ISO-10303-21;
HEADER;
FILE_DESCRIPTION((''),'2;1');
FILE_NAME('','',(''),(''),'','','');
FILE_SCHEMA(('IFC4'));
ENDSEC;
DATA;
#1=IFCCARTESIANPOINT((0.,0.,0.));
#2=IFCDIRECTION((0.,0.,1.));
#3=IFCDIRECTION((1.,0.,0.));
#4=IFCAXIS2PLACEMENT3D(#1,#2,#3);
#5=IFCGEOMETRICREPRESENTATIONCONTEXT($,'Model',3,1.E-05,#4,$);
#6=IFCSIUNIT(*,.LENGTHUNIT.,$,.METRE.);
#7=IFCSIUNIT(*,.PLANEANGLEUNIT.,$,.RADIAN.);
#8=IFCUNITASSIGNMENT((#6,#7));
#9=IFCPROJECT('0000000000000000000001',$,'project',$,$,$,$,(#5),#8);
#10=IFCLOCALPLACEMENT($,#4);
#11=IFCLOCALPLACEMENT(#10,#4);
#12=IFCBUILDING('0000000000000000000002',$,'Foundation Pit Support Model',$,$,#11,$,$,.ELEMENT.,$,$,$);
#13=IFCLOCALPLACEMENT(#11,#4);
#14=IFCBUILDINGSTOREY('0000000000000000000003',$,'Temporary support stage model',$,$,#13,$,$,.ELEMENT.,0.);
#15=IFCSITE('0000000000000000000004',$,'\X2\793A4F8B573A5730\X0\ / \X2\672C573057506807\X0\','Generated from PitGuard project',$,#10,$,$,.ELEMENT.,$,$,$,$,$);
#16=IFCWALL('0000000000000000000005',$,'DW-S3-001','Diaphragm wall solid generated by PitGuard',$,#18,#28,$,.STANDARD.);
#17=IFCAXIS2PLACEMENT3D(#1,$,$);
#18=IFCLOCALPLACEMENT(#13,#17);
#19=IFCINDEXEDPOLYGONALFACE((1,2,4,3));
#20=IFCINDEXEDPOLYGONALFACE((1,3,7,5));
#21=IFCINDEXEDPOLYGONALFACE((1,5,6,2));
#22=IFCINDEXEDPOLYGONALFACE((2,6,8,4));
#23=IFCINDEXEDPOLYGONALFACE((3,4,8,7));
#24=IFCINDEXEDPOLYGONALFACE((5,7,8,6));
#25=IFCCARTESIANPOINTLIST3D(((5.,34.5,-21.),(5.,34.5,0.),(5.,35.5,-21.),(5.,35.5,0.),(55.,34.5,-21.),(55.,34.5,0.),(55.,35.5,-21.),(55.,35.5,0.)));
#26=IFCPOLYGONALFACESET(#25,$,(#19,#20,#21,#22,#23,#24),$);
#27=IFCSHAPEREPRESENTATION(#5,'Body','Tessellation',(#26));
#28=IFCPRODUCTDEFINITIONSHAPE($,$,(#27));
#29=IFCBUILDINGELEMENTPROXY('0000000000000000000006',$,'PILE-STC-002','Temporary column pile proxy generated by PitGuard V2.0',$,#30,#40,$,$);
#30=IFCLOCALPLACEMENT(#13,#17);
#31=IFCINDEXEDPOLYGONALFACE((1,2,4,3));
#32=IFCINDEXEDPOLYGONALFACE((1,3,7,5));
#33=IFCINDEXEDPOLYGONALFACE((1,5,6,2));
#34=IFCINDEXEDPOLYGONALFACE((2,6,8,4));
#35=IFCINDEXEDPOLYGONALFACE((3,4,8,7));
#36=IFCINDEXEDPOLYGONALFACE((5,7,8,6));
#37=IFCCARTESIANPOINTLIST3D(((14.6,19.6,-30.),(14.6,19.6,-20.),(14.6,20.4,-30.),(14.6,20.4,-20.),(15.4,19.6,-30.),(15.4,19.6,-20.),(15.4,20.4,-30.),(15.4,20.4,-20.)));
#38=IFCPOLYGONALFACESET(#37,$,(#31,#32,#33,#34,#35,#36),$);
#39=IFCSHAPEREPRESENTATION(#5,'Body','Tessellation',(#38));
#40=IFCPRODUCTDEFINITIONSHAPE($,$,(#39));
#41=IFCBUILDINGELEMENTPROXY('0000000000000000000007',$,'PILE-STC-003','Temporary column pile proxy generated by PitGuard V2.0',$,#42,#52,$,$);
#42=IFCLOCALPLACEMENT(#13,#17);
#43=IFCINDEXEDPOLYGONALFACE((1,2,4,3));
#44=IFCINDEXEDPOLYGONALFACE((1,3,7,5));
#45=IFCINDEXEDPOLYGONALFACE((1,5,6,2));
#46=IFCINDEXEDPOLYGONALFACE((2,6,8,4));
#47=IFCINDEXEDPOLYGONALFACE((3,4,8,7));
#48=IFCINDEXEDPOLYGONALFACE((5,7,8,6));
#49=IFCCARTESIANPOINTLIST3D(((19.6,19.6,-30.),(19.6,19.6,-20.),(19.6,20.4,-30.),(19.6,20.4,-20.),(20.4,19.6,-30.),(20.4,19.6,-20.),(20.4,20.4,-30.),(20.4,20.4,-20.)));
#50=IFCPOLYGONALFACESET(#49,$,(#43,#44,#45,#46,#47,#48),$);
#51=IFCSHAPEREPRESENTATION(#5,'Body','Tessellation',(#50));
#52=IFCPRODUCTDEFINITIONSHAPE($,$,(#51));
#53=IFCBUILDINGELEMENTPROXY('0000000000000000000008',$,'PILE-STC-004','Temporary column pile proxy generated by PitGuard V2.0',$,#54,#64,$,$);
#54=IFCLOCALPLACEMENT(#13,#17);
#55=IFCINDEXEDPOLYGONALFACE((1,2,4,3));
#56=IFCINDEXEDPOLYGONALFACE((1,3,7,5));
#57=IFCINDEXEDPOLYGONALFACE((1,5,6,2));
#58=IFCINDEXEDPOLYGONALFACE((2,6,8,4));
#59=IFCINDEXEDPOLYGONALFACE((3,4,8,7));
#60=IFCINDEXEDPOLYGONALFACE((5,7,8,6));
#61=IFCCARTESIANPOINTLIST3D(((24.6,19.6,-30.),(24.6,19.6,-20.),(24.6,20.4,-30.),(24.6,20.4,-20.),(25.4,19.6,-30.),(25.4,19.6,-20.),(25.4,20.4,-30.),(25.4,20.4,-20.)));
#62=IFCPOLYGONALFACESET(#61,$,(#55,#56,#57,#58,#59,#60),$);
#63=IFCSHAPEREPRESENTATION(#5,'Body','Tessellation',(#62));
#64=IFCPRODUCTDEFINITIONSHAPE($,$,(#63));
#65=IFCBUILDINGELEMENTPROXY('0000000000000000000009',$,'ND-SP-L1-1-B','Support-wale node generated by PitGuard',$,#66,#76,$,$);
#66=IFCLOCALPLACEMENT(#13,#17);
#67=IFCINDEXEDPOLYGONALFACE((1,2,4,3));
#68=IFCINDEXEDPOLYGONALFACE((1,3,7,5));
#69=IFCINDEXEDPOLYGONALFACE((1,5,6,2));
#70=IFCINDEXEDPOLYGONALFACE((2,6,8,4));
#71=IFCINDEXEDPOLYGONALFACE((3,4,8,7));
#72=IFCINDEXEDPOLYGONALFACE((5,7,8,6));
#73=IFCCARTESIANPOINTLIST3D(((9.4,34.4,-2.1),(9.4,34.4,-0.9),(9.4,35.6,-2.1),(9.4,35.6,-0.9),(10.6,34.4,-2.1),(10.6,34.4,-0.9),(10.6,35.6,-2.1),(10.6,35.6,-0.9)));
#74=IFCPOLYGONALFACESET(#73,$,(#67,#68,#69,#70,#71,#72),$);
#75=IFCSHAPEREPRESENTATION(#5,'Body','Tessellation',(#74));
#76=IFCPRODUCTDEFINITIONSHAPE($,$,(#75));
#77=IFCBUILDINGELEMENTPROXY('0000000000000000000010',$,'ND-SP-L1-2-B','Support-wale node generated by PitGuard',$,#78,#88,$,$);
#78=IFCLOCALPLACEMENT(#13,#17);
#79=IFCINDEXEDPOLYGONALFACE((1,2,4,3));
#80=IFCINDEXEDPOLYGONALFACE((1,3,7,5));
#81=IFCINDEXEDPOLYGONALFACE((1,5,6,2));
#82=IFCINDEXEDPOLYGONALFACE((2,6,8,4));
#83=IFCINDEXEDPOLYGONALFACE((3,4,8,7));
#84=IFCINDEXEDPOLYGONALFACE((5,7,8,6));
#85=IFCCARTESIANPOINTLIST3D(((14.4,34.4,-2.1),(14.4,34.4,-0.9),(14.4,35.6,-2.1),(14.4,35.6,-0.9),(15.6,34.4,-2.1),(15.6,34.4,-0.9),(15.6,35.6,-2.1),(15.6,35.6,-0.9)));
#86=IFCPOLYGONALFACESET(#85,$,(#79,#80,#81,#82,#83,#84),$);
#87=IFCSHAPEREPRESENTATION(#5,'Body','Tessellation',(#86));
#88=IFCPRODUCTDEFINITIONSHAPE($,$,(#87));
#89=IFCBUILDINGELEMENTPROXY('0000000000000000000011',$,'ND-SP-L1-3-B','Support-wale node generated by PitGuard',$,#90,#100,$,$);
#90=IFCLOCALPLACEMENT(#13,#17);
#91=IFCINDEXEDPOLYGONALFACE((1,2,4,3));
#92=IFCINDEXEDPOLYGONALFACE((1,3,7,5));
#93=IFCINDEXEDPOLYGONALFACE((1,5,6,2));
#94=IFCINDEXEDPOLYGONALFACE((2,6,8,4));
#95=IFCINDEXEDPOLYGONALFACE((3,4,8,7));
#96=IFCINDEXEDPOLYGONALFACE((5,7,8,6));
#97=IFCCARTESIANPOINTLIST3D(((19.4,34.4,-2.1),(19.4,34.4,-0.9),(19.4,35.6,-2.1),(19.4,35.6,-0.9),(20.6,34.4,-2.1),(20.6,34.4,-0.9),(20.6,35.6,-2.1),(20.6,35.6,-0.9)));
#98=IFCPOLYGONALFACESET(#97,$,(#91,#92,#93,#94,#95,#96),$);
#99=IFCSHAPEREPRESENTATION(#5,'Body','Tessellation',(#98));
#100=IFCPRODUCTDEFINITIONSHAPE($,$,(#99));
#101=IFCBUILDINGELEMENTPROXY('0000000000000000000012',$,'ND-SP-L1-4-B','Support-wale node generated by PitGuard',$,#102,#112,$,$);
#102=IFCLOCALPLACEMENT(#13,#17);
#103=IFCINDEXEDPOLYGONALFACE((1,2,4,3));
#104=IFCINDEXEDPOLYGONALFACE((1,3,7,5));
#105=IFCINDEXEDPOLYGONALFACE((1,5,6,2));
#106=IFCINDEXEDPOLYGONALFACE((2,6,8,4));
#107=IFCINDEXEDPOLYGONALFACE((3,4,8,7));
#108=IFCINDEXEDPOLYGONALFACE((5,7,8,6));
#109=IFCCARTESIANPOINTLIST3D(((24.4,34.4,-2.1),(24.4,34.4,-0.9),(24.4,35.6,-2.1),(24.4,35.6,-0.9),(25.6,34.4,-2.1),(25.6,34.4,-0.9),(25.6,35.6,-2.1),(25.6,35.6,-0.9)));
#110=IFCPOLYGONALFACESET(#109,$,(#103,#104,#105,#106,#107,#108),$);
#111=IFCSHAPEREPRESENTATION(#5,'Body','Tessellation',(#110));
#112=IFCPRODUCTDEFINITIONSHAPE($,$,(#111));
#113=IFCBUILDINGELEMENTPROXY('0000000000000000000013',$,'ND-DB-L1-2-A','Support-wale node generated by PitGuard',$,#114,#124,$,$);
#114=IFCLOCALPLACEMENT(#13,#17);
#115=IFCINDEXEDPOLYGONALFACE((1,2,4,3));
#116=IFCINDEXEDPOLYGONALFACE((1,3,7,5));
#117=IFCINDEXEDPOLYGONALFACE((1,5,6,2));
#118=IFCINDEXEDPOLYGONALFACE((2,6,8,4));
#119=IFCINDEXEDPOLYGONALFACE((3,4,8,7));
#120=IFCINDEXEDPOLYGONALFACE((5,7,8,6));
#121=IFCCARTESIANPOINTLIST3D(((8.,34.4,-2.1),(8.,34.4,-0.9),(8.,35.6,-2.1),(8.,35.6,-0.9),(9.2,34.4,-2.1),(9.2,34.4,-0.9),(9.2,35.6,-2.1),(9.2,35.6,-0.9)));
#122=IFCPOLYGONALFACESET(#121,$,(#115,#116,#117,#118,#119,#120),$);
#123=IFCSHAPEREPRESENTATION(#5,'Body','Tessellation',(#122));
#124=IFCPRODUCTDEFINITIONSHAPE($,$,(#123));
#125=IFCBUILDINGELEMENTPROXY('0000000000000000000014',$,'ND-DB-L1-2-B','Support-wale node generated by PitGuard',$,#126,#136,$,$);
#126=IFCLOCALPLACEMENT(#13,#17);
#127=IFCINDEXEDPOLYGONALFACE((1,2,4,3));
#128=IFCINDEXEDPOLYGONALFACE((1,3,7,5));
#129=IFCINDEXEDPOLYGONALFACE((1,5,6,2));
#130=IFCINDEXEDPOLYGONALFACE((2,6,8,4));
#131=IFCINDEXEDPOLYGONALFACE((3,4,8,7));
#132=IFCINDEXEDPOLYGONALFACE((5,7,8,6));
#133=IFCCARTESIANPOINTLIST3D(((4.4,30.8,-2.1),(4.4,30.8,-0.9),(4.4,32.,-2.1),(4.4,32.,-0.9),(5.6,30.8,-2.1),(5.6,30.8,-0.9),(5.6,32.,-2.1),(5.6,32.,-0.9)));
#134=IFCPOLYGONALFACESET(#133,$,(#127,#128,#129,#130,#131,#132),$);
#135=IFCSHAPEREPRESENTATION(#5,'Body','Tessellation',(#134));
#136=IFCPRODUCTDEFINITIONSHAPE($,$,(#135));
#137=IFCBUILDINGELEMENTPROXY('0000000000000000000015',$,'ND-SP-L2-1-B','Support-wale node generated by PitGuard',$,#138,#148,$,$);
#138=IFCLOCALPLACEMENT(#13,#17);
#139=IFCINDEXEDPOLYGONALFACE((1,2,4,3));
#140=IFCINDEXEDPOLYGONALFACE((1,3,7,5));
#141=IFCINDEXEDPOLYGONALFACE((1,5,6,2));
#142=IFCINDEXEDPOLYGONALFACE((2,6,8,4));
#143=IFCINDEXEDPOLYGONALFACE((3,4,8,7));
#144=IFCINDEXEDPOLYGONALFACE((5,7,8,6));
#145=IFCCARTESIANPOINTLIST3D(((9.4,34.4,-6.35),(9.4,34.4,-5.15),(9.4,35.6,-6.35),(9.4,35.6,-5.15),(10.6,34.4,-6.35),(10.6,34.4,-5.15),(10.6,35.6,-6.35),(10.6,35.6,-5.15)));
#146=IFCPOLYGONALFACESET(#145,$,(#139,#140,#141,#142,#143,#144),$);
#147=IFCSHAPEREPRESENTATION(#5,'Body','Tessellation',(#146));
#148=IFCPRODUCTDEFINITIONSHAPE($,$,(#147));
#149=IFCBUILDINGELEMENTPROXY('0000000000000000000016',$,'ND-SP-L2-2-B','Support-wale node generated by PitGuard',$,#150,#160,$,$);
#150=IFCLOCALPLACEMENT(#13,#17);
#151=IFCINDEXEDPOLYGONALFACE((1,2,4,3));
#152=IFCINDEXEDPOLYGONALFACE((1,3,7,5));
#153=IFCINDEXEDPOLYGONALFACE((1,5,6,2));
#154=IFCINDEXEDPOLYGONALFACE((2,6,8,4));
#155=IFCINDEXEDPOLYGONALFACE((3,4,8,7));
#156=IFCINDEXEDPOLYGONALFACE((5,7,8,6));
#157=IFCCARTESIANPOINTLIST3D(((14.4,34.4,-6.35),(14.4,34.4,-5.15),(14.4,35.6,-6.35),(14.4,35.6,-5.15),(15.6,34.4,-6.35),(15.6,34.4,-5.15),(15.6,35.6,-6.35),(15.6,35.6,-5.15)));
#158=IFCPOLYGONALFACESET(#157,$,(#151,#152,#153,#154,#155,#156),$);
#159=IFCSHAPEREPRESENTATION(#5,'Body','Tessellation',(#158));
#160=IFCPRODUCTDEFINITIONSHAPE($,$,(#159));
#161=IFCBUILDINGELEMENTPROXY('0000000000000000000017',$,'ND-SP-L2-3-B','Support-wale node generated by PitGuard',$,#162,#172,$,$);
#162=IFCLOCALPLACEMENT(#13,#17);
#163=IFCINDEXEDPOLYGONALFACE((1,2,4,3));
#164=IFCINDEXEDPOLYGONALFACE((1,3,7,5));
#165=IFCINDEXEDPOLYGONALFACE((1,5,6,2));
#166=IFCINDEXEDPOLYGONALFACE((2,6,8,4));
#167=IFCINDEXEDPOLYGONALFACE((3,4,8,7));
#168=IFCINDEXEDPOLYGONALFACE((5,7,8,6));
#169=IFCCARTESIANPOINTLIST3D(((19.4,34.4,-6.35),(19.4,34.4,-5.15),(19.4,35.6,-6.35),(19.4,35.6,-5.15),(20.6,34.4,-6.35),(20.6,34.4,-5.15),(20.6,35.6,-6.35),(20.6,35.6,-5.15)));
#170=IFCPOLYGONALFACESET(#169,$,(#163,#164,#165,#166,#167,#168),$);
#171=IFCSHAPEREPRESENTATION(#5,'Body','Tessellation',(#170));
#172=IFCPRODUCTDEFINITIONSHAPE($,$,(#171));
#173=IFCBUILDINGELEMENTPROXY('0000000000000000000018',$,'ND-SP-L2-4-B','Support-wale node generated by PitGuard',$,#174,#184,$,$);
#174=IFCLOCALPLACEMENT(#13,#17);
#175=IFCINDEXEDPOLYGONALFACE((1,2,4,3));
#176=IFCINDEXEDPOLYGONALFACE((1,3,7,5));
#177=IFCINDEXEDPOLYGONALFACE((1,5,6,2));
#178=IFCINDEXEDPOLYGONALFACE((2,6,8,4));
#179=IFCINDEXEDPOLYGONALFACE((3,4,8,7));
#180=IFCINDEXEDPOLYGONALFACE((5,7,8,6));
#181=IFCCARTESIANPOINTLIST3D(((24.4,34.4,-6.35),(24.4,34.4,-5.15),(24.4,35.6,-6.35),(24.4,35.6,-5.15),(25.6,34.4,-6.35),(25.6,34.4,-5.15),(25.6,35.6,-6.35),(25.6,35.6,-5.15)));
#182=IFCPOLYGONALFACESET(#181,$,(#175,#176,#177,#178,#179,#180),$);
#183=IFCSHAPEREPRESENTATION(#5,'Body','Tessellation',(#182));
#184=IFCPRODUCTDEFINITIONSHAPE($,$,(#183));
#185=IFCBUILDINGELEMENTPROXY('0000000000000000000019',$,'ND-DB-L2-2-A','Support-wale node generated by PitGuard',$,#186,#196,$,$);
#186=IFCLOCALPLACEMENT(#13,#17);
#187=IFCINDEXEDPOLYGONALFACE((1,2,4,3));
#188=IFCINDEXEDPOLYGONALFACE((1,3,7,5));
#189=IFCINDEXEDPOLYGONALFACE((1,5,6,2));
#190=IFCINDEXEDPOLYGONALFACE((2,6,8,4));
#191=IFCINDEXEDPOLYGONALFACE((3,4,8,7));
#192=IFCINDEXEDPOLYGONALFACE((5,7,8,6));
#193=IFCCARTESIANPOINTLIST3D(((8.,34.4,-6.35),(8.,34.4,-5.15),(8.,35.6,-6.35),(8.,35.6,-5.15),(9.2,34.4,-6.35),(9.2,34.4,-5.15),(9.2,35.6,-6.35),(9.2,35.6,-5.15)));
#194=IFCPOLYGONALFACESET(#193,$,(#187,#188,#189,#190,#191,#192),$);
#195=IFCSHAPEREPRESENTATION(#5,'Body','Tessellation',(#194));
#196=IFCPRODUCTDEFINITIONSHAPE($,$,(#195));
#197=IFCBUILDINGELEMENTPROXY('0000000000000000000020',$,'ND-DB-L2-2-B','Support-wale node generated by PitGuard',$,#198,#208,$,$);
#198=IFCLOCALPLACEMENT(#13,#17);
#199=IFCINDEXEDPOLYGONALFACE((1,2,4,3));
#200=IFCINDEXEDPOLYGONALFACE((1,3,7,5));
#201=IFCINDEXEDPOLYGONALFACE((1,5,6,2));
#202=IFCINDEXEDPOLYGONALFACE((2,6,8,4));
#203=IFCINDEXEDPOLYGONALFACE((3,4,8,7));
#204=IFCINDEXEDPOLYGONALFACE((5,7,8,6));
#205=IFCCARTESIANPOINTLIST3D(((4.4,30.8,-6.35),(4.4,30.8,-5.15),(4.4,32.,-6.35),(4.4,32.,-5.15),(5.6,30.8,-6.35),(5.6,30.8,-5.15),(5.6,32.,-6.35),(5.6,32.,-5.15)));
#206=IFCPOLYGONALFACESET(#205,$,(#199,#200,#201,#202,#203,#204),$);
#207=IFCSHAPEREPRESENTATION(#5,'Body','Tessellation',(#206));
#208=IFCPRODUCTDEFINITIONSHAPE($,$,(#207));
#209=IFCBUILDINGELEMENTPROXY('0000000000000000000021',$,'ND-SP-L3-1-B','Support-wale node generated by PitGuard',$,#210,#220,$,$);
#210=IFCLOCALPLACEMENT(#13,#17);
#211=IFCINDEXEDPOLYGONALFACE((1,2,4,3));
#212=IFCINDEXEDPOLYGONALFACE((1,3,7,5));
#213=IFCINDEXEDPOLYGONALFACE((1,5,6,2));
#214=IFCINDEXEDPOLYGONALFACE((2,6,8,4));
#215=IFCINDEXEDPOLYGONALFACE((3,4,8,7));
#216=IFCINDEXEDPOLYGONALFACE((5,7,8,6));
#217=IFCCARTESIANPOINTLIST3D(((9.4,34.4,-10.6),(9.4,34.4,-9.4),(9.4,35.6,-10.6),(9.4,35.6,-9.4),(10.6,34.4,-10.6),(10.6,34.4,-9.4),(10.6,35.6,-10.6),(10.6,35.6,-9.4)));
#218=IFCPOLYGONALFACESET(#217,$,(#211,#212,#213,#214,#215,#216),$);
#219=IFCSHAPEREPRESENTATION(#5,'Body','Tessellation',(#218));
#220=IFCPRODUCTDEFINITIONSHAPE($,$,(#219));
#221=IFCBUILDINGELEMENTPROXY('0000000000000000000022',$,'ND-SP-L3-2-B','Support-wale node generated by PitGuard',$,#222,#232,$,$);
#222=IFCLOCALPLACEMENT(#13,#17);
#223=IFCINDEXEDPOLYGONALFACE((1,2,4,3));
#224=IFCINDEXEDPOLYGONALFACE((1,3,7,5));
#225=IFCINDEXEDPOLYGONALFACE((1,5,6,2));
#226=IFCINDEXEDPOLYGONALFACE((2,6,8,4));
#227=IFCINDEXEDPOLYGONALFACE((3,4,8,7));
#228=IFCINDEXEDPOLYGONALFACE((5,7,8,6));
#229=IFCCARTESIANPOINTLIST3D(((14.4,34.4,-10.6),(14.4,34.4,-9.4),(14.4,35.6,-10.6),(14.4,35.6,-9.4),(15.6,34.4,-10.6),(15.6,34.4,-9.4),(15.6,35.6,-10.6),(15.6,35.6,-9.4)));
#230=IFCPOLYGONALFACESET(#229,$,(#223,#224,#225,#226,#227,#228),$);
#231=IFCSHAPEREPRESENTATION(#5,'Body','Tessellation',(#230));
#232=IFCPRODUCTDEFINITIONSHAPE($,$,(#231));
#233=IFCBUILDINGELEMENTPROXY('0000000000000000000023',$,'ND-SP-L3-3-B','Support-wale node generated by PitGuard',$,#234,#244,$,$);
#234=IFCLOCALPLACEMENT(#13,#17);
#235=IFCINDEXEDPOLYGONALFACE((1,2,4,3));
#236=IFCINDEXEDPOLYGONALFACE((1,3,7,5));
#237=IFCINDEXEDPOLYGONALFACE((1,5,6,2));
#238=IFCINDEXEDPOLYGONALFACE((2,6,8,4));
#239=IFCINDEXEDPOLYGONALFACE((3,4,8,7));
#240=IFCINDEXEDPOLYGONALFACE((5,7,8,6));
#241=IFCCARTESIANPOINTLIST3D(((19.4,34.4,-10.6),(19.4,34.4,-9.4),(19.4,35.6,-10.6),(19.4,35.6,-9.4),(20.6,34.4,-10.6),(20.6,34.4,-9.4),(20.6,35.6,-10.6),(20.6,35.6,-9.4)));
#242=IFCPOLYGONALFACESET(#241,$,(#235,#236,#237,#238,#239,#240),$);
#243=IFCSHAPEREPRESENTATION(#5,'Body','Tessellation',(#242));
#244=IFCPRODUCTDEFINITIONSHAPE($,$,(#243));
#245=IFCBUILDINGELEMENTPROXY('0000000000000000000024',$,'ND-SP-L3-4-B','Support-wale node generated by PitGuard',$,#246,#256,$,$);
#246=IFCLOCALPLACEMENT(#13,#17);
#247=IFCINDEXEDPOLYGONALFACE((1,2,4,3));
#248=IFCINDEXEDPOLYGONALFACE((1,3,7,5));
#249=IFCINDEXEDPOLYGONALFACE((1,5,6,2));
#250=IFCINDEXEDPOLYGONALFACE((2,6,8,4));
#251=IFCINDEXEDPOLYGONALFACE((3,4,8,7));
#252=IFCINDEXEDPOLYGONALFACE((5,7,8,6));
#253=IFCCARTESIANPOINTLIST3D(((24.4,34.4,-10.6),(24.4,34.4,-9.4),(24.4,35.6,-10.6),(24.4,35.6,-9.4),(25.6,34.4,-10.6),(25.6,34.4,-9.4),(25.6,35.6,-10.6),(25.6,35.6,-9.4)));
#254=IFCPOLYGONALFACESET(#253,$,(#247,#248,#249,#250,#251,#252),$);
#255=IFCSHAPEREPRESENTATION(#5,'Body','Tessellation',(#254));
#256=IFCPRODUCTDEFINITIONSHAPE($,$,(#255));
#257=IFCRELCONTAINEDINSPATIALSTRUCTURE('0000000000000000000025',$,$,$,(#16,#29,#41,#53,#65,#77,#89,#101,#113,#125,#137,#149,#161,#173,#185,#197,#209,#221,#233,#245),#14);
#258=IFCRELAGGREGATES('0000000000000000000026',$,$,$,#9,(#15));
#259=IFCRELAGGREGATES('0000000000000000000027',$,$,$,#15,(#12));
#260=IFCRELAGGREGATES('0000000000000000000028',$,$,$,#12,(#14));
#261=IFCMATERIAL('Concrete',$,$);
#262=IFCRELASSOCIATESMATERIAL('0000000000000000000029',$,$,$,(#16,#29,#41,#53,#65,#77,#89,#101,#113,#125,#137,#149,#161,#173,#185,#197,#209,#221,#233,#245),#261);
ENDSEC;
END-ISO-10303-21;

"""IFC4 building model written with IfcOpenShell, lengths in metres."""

from ifc_helpers import new_model, si_unit, frame, origin_with_axes, origin_2d, place, context, project, spatial, rectangle, extrude, material, element, save


model = new_model("IFC4")

# Units and contexts
model_context = context("Model", 3, precision=1e-05, world=origin_with_axes())
ifc_project = project(units=[si_unit("LENGTHUNIT", "METRE"), si_unit("PLANEANGLEUNIT", "RADIAN")], contexts=[model_context])

# Site, building, storey
site_placement = place(None, origin_with_axes())
site = spatial("IfcSite", under=ifc_project, at=site_placement, Name="示例场地 / 本地坐标", Description="Generated from PitGuard project", CompositionType="ELEMENT")
building_placement = place(site_placement, origin_with_axes())
building = spatial("IfcBuilding", under=site, at=building_placement, Name="Foundation Pit Support Model", CompositionType="ELEMENT")
storey_placement = place(building_placement, origin_with_axes())
storey = spatial("IfcBuildingStorey", under=building, at=storey_placement, Name="Temporary support stage model", CompositionType="ELEMENT", Elevation=0.0)

# Shared definitions
ifc_material_1 = material(Name="Concrete")

# Wall
wall_placement = place(storey_placement, frame((30.0, 35.0, -21.0), z_axis=(0.0, 0.0, 1.0), x_axis=(-1.0, 0.0, 0.0)))
element("IfcWall", 1, at=wall_placement, inside=storey, material=ifc_material_1, Name="DW-S3-001", Description="Diaphragm wall solid generated by PitGuard", PredefinedType="STANDARD", context=model_context, shape_type="SweptSolid", body=[
    extrude(rectangle(XDim=50.0, YDim=1.0, at=origin_2d()), origin_with_axes(), (0.0, 0.0, 1.0), 21.0),
])

# Building element proxies
for number, where, z_axis, x_axis, name in (
    (2, (15.0, 20.0, -30.0), (0.0, 0.0, 1.0), (1.0, 0.0, 0.0), "PILE-STC-002"),
    (3, (20.0, 20.0, -30.0), (0.0, 0.0, 1.0), (1.0, 0.0, 0.0), "PILE-STC-003"),
    (4, (25.0, 20.0, -30.0), (0.0, 0.0, 1.0), (1.0, 0.0, 0.0), "PILE-STC-004"),
):
    element("IfcBuildingElementProxy", number, at=place(storey_placement, frame(where, z_axis=z_axis, x_axis=x_axis)), inside=storey, material=ifc_material_1, Name=name, Description="Temporary column pile proxy generated by PitGuard V2.0", context=model_context, shape_type="SweptSolid", body=[
        extrude(rectangle(XDim=0.8, YDim=0.8, at=origin_2d()), origin_with_axes(), (0.0, 0.0, 1.0), 10.0),
    ])
for number, where, z_axis, x_axis, name in (
    (5, (10.0, 35.0, -2.1), (0.0, 0.0, 1.0), (1.0, 0.0, 0.0), "ND-SP-L1-1-B"),
    (6, (15.0, 35.0, -2.1), (0.0, 0.0, 1.0), (1.0, 0.0, 0.0), "ND-SP-L1-2-B"),
    (7, (20.0, 35.0, -2.1), (0.0, 0.0, 1.0), (1.0, 0.0, 0.0), "ND-SP-L1-3-B"),
    (8, (25.0, 35.0, -2.1), (0.0, 0.0, 1.0), (1.0, 0.0, 0.0), "ND-SP-L1-4-B"),
    (9, (8.6, 35.0, -2.1), (0.0, 0.0, 1.0), (1.0, 0.0, 0.0), "ND-DB-L1-2-A"),
    (10, (5.0, 31.4, -2.1), (0.0, 0.0, 1.0), (1.0, 0.0, 0.0), "ND-DB-L1-2-B"),
    (11, (10.0, 35.0, -6.35), (0.0, 0.0, 1.0), (1.0, 0.0, 0.0), "ND-SP-L2-1-B"),
    (12, (15.0, 35.0, -6.35), (0.0, 0.0, 1.0), (1.0, 0.0, 0.0), "ND-SP-L2-2-B"),
    (13, (20.0, 35.0, -6.35), (0.0, 0.0, 1.0), (1.0, 0.0, 0.0), "ND-SP-L2-3-B"),
    (14, (25.0, 35.0, -6.35), (0.0, 0.0, 1.0), (1.0, 0.0, 0.0), "ND-SP-L2-4-B"),
    (15, (8.6, 35.0, -6.35), (0.0, 0.0, 1.0), (1.0, 0.0, 0.0), "ND-DB-L2-2-A"),
    (16, (5.0, 31.4, -6.35), (0.0, 0.0, 1.0), (1.0, 0.0, 0.0), "ND-DB-L2-2-B"),
    (17, (10.0, 35.0, -10.6), (0.0, 0.0, 1.0), (1.0, 0.0, 0.0), "ND-SP-L3-1-B"),
    (18, (15.0, 35.0, -10.6), (0.0, 0.0, 1.0), (1.0, 0.0, 0.0), "ND-SP-L3-2-B"),
    (19, (20.0, 35.0, -10.6), (0.0, 0.0, 1.0), (1.0, 0.0, 0.0), "ND-SP-L3-3-B"),
    (20, (25.0, 35.0, -10.6), (0.0, 0.0, 1.0), (1.0, 0.0, 0.0), "ND-SP-L3-4-B"),
):
    element("IfcBuildingElementProxy", number, at=place(storey_placement, frame(where, z_axis=z_axis, x_axis=x_axis)), inside=storey, material=ifc_material_1, Name=name, Description="Support-wale node generated by PitGuard", context=model_context, shape_type="SweptSolid", body=[
        extrude(rectangle(XDim=1.2, YDim=1.2, at=origin_2d()), origin_with_axes(), (0.0, 0.0, 1.0), 1.2),
    ])

save(model, "model.ifc")
